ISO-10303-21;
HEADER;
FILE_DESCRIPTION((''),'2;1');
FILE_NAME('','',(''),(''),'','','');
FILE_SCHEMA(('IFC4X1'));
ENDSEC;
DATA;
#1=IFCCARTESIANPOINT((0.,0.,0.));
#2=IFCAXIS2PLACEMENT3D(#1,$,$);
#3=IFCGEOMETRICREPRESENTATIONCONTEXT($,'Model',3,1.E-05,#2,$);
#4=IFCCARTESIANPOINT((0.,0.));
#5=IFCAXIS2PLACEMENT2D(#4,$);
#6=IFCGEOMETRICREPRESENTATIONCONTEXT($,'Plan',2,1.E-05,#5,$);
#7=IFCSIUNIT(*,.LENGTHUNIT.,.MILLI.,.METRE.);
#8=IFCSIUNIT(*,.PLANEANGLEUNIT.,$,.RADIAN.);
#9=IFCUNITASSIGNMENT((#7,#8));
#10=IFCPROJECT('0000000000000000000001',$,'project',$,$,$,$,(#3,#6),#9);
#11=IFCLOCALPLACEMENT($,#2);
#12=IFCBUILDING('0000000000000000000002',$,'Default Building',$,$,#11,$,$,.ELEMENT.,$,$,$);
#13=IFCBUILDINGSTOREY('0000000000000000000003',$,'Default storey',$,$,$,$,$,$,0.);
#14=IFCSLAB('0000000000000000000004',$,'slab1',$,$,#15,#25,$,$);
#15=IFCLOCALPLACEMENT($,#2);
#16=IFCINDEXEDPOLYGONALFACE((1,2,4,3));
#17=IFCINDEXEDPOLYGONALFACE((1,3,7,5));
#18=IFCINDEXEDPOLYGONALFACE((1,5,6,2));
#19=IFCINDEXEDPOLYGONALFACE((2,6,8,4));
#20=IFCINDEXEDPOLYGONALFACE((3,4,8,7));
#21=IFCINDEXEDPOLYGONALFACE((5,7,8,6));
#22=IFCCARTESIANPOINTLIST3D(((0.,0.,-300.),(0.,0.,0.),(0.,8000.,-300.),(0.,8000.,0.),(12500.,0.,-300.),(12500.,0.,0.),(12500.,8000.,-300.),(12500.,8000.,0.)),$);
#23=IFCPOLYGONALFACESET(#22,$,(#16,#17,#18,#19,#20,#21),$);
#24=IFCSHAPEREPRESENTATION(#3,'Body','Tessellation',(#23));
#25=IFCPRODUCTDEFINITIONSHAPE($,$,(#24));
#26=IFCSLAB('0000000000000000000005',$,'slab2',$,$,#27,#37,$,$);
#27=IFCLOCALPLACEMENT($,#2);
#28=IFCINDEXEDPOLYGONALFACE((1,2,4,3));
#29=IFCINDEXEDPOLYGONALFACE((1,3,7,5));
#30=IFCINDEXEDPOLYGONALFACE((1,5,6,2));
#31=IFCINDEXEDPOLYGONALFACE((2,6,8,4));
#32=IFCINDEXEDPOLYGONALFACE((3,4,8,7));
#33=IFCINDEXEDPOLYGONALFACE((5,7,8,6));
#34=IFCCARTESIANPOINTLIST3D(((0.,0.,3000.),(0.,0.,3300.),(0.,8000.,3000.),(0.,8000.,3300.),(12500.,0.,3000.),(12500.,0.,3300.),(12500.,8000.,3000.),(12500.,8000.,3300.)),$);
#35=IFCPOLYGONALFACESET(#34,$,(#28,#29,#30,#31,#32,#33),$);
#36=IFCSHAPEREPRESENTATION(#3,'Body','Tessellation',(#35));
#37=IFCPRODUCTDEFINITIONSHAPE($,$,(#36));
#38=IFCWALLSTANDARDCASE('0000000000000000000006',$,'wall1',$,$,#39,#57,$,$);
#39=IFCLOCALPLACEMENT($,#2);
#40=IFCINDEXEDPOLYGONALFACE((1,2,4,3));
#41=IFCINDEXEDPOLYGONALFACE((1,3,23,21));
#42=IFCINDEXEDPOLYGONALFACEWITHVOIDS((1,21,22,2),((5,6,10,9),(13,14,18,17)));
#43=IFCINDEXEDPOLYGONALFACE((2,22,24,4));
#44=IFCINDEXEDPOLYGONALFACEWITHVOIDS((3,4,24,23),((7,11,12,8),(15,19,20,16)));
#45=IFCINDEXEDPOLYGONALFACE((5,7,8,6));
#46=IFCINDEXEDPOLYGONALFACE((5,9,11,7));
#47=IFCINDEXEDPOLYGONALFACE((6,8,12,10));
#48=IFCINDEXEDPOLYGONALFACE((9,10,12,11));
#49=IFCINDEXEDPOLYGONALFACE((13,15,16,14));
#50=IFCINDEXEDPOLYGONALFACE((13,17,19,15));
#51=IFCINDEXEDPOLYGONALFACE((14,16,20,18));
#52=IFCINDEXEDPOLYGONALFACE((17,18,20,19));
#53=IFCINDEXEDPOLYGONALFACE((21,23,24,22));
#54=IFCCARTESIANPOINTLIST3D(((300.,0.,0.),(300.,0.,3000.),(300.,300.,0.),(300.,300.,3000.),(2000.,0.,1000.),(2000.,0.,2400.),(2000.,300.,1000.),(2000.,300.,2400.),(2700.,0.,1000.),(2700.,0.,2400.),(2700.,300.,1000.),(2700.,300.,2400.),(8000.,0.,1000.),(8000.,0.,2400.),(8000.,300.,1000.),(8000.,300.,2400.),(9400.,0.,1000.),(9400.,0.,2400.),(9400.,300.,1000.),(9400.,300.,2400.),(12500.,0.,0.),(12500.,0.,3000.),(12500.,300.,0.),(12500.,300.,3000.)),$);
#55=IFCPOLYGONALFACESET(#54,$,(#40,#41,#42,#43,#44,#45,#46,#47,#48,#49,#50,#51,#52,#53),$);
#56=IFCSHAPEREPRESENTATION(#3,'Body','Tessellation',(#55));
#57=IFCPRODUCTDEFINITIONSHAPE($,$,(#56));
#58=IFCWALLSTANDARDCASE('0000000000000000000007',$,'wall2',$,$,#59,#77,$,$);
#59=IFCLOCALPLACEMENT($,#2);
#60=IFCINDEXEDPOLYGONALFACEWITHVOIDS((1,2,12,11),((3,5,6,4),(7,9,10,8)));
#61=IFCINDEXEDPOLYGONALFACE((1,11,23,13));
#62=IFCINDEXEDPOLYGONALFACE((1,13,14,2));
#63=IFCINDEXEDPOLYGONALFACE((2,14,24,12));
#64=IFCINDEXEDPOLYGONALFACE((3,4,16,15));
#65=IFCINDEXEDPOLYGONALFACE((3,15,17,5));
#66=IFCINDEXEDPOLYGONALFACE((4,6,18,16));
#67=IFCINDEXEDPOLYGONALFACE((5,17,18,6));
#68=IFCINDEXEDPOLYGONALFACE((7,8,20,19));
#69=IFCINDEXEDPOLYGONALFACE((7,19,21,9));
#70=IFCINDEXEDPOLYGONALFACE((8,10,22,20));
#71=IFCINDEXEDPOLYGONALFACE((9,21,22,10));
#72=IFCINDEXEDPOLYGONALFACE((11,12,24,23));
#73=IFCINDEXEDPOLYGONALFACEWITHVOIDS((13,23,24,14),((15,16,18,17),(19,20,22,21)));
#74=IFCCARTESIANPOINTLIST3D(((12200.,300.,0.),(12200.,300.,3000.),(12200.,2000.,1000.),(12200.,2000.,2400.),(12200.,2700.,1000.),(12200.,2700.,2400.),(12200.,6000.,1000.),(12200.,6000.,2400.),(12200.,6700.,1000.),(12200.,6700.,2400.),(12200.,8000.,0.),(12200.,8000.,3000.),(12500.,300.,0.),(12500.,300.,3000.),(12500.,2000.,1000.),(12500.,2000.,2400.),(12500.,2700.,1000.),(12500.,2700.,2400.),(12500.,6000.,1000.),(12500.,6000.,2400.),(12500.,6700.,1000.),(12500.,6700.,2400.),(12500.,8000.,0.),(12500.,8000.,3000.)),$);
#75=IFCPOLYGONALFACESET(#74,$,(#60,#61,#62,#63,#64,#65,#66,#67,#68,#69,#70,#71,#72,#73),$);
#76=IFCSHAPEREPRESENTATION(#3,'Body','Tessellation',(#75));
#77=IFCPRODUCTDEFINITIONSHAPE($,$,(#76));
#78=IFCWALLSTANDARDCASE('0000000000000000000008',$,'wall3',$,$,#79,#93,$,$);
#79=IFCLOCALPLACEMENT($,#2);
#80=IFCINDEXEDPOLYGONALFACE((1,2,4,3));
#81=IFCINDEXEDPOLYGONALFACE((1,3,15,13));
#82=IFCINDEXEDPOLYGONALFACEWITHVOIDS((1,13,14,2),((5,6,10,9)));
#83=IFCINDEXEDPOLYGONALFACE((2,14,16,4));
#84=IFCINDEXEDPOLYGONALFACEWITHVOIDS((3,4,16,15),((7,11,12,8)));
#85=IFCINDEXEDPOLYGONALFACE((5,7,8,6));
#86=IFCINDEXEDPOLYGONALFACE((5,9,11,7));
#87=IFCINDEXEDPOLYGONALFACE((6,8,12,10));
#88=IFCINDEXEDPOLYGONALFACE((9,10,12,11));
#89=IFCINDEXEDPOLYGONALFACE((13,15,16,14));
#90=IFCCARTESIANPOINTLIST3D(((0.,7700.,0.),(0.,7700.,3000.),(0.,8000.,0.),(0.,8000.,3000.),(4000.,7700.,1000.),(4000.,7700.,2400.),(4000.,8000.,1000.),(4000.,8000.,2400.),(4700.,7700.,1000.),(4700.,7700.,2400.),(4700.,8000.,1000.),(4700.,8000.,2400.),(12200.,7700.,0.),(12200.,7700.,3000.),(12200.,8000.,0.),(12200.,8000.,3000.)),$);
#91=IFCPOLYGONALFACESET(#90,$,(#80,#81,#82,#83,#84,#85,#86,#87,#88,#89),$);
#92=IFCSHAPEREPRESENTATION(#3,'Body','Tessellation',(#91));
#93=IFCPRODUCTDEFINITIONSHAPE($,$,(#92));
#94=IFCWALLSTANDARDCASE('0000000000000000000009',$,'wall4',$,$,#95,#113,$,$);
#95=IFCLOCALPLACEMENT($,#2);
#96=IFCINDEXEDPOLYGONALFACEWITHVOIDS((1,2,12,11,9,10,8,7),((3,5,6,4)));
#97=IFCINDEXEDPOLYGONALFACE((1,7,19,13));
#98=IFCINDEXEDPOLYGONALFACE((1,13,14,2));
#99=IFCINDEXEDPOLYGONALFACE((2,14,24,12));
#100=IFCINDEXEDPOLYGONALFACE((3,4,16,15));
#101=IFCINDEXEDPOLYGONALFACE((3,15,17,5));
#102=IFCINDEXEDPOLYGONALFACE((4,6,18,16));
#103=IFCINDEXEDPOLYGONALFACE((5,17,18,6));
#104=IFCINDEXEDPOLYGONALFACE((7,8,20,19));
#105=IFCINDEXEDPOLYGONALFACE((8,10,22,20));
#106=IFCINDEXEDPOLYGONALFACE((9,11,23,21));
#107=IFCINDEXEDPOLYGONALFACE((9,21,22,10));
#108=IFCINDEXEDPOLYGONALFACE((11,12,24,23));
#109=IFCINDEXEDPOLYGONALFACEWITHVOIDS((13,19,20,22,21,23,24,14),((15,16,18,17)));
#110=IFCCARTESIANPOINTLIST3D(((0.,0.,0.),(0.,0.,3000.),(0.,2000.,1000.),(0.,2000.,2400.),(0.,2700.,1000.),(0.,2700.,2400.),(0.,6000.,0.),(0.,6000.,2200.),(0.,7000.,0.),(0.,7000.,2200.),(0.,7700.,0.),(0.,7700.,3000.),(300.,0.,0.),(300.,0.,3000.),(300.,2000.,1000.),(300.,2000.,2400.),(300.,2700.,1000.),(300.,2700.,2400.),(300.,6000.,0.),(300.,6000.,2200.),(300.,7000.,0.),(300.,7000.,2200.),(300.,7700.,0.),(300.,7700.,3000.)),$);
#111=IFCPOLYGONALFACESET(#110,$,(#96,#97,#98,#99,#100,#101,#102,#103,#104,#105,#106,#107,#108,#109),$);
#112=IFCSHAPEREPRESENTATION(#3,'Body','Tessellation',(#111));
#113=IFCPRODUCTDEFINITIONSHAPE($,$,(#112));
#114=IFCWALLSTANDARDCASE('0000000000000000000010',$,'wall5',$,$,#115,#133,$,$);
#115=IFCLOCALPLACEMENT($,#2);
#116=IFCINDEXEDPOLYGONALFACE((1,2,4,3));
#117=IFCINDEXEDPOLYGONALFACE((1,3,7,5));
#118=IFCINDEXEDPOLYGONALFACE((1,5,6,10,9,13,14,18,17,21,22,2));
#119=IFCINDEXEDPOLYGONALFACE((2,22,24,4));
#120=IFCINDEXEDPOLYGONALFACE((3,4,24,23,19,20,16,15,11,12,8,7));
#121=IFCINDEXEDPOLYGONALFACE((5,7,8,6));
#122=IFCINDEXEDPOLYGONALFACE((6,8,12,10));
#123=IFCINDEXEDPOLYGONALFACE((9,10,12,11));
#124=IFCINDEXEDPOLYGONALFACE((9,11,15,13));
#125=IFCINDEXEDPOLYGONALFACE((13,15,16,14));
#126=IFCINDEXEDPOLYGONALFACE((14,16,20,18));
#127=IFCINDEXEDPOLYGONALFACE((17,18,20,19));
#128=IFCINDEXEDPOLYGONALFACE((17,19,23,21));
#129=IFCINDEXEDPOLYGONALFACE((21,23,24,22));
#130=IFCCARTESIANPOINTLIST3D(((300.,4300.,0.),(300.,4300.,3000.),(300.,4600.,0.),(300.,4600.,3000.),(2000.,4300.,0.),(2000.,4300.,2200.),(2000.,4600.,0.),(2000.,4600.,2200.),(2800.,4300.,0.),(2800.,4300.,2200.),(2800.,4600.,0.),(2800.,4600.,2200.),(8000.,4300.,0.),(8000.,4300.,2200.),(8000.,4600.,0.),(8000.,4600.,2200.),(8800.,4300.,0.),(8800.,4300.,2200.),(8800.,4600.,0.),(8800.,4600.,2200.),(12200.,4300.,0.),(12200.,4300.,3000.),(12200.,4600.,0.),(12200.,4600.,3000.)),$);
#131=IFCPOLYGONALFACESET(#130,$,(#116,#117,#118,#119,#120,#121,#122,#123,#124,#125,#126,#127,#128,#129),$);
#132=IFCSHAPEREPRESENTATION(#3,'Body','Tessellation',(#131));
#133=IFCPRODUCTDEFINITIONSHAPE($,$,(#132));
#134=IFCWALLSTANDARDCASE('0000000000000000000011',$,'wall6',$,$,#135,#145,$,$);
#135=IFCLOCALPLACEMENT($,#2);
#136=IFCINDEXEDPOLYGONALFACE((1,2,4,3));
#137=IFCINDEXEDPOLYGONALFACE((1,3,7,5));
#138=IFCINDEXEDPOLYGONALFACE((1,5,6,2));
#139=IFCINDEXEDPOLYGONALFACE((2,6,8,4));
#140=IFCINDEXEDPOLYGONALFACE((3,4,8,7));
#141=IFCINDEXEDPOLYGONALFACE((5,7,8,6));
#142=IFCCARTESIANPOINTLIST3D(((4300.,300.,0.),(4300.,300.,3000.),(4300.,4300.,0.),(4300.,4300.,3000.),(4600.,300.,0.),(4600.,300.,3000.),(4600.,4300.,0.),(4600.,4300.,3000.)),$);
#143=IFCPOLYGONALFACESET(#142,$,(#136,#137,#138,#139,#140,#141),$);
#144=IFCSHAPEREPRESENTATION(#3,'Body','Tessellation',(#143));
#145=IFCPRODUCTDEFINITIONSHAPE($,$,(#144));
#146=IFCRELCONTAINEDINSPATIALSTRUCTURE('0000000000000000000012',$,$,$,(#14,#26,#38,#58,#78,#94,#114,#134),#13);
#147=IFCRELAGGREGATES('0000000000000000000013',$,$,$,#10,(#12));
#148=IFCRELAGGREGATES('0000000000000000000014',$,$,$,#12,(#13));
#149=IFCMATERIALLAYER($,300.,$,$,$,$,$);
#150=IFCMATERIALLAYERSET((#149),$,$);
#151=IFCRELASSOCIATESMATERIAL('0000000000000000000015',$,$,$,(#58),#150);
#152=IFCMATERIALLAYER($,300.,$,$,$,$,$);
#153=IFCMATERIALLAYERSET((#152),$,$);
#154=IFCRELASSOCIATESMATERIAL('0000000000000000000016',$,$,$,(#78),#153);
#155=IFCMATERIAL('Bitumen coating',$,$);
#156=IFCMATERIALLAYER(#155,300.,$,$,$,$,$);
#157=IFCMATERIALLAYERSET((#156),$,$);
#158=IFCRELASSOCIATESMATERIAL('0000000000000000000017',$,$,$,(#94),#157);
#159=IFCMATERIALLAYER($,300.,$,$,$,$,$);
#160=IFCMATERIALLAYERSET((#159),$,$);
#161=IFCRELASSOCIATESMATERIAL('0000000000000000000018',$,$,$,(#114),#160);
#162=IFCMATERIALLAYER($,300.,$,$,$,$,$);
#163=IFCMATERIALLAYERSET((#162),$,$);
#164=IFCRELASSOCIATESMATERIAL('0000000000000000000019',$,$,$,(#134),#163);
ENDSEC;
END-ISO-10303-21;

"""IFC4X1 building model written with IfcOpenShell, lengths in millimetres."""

from ifc_helpers import new_model, si_unit, frame, origin, origin_2d, place, context, project, spatial, polyline, outline, extrude, material, layer, layer_set, layer_usage, element, save


model = new_model("IFC4X1")

# Units and contexts
model_context = context("Model", 3, precision=1e-05, world=origin())
plan_context = context("Plan", 2, precision=1e-05, world=origin_2d())
ifc_project = project(units=[si_unit("LENGTHUNIT", "METRE", prefix="MILLI"), si_unit("PLANEANGLEUNIT", "RADIAN")], contexts=[model_context, plan_context])

# Building, storey
building_placement = place(None, origin())
building = spatial("IfcBuilding", under=ifc_project, at=building_placement, Name="Default Building", CompositionType="ELEMENT")
storey = spatial("IfcBuildingStorey", under=building, Name="Default storey", Elevation=0.0)

# Slabs
slab_1_placement = place(None, frame((0.0, 0.0, -300.0), z_axis=(0.0, 0.0, 1.0)))
element("IfcSlab", 1, at=slab_1_placement, inside=storey, Name="slab1", context=model_context, shape_type="SweptSolid", body=[
    extrude(outline(polyline([(0.0, 0.0), (12500.0, 0.0), (12500.0, 8000.0), (0.0, 8000.0), (0.0, 0.0)])), origin(), (0.0, 0.0, 1.0), 300.0),
])
slab_2_placement = place(None, frame((0.0, 0.0, 3000.0), z_axis=(0.0, 0.0, 1.0)))
element("IfcSlab", 2, at=slab_2_placement, inside=storey, Name="slab2", context=model_context, shape_type="SweptSolid", body=[
    extrude(outline(polyline([(0.0, 0.0), (0.0, 8000.0), (12500.0, 8000.0), (12500.0, 0.0), (0.0, 0.0)])), origin(), (0.0, 0.0, 1.0), 300.0),
])

# Walls, openings
wall_1_placement = place(None, frame((0.0, 0.0, 0.0), z_axis=(0.0, 0.0, 1.0)))
wall_1 = element("IfcWallStandardCase", 3, at=wall_1_placement, inside=storey, Name="wall1", context=model_context, shape_type="SweptSolid", body=[
    extrude(outline(polyline([(300.0, 0.0), (12500.0, 0.0), (12500.0, 300.0), (300.0, 300.0), (300.0, 0.0)])), origin(), (0.0, 0.0, 1.0), 3000.0),
])
opening_1_placement = place(None, frame((0.0, 0.0, 1000.0), z_axis=(0.0, 0.0, 1.0)))
element("IfcOpeningElement", 4, at=opening_1_placement, inside=storey, cuts=wall_1, context=model_context, shape_type="SweptSolid", body=[
    extrude(outline(polyline([(8000.0, 0.0), (9400.0, 0.0), (9400.0, 300.0), (8000.0, 300.0), (8000.0, 0.0)])), origin(), (0.0, 0.0, 1.0), 1400.0),
])
opening_2_placement = place(None, frame((0.0, 0.0, 1000.0), z_axis=(0.0, 0.0, 1.0)))
element("IfcOpeningElement", 5, at=opening_2_placement, inside=storey, cuts=wall_1, context=model_context, shape_type="SweptSolid", body=[
    extrude(outline(polyline([(2000.0, 0.0), (2700.0, 0.0), (2700.0, 300.0), (2000.0, 300.0), (2000.0, 0.0)])), origin(), (0.0, 0.0, 1.0), 1400.0),
])
ifc_layer_1 = layer(None, 300.0)
ifc_layer_set_1 = layer_set([ifc_layer_1])
ifc_layer_usage_1 = layer_usage(ifc_layer_set_1, "AXIS2", "NEGATIVE", 150.0)
wall_2_placement = place(None, frame((0.0, 0.0, 0.0), z_axis=(0.0, 0.0, 1.0)))
wall_2 = element("IfcWallStandardCase", 6, at=wall_2_placement, inside=storey, material=ifc_layer_usage_1, Name="wall2", context=model_context, shape_type="SweptSolid", body=[
    extrude(outline(polyline([(12500.0, 300.0), (12500.0, 8000.0), (12200.0, 8000.0), (12200.0, 300.0), (12500.0, 300.0)])), origin(), (0.0, 0.0, 1.0), 3000.0),
])
opening_3_placement = place(None, frame((0.0, 0.0, 1000.0), z_axis=(0.0, 0.0, 1.0)))
element("IfcOpeningElement", 7, at=opening_3_placement, inside=storey, cuts=wall_2, context=model_context, shape_type="SweptSolid", body=[
    extrude(outline(polyline([(12500.0, 6000.0), (12500.0, 6700.0), (12200.0, 6700.0), (12200.0, 6000.0), (12500.0, 6000.0)])), origin(), (0.0, 0.0, 1.0), 1400.0),
])
opening_4_placement = place(None, frame((0.0, 0.0, 1000.0), z_axis=(0.0, 0.0, 1.0)))
element("IfcOpeningElement", 8, at=opening_4_placement, inside=storey, cuts=wall_2, context=model_context, shape_type="SweptSolid", body=[
    extrude(outline(polyline([(12500.0, 2000.0), (12500.0, 2700.0), (12200.0, 2700.0), (12200.0, 2000.0), (12500.0, 2000.0)])), origin(), (0.0, 0.0, 1.0), 1400.0),
])

# Wall, opening
ifc_layer_2 = layer(None, 300.0)
ifc_layer_set_2 = layer_set([ifc_layer_2])
ifc_layer_usage_2 = layer_usage(ifc_layer_set_2, "AXIS2", "NEGATIVE", 150.0)
wall_3_placement = place(None, frame((0.0, 0.0, 0.0), z_axis=(0.0, 0.0, 1.0)))
wall_3 = element("IfcWallStandardCase", 9, at=wall_3_placement, inside=storey, material=ifc_layer_usage_2, Name="wall3", context=model_context, shape_type="SweptSolid", body=[
    extrude(outline(polyline([(12200.0, 8000.0), (0.0, 8000.0), (0.0, 7700.0), (12200.0, 7700.0), (12200.0, 8000.0)])), origin(), (0.0, 0.0, 1.0), 3000.0),
])
opening_5_placement = place(None, frame((0.0, 0.0, 1000.0), z_axis=(0.0, 0.0, 1.0)))
element("IfcOpeningElement", 10, at=opening_5_placement, inside=storey, cuts=wall_3, context=model_context, shape_type="SweptSolid", body=[
    extrude(outline(polyline([(4000.0, 8000.0), (4700.0, 8000.0), (4700.0, 7700.0), (4000.0, 7700.0), (4000.0, 8000.0)])), origin(), (0.0, 0.0, 1.0), 1400.0),
])

# Walls, openings
ifc_material = material(Name="Bitumen coating")
ifc_layer_3 = layer(ifc_material, 300.0)
ifc_layer_set_3 = layer_set([ifc_layer_3])
ifc_layer_usage_3 = layer_usage(ifc_layer_set_3, "AXIS2", "NEGATIVE", 150.0)
wall_4_placement = place(None, frame((0.0, 0.0, 0.0), z_axis=(0.0, 0.0, 1.0)))
wall_4 = element("IfcWallStandardCase", 11, at=wall_4_placement, inside=storey, material=ifc_layer_usage_3, Name="wall4", context=model_context, shape_type="SweptSolid", body=[
    extrude(outline(polyline([(0.0, 7700.0), (0.0, 0.0), (300.0, 0.0), (300.0, 7700.0), (0.0, 7700.0)])), origin(), (0.0, 0.0, 1.0), 3000.0),
])
opening_6_placement = place(None, frame((0.0, 0.0, 0.0), z_axis=(0.0, 0.0, 1.0)))
element("IfcOpeningElement", 12, at=opening_6_placement, inside=storey, cuts=wall_4, context=model_context, shape_type="SweptSolid", body=[
    extrude(outline(polyline([(0.0, 6000.0), (0.0, 7000.0), (300.0, 7000.0), (300.0, 6000.0), (0.0, 6000.0)])), origin(), (0.0, 0.0, 1.0), 2200.0),
])
opening_7_placement = place(None, frame((0.0, 0.0, 1000.0), z_axis=(0.0, 0.0, 1.0)))
element("IfcOpeningElement", 13, at=opening_7_placement, inside=storey, cuts=wall_4, context=model_context, shape_type="SweptSolid", body=[
    extrude(outline(polyline([(0.0, 2000.0), (0.0, 2700.0), (300.0, 2700.0), (300.0, 2000.0), (0.0, 2000.0)])), origin(), (0.0, 0.0, 1.0), 1400.0),
])
ifc_layer_4 = layer(None, 300.0)
ifc_layer_set_4 = layer_set([ifc_layer_4])
ifc_layer_usage_4 = layer_usage(ifc_layer_set_4, "AXIS2", "NEGATIVE", 150.0)
wall_5_placement = place(None, frame((0.0, 0.0, 0.0), z_axis=(0.0, 0.0, 1.0)))
wall_5 = element("IfcWallStandardCase", 14, at=wall_5_placement, inside=storey, material=ifc_layer_usage_4, Name="wall5", context=model_context, shape_type="SweptSolid", body=[
    extrude(outline(polyline([(12200.0, 4600.0), (300.0, 4600.0), (300.0, 4300.0), (12200.0, 4300.0), (12200.0, 4600.0)])), origin(), (0.0, 0.0, 1.0), 3000.0),
])
opening_8_placement = place(None, frame((0.0, 0.0, 0.0), z_axis=(0.0, 0.0, 1.0)))
element("IfcOpeningElement", 15, at=opening_8_placement, inside=storey, cuts=wall_5, context=model_context, shape_type="SweptSolid", body=[
    extrude(outline(polyline([(2000.0, 4600.0), (2800.0, 4600.0), (2800.0, 4300.0), (2000.0, 4300.0), (2000.0, 4600.0)])), origin(), (0.0, 0.0, 1.0), 2200.0),
])
opening_9_placement = place(None, frame((0.0, 0.0, 0.0), z_axis=(0.0, 0.0, 1.0)))
element("IfcOpeningElement", 16, at=opening_9_placement, inside=storey, cuts=wall_5, context=model_context, shape_type="SweptSolid", body=[
    extrude(outline(polyline([(8000.0, 4600.0), (8800.0, 4600.0), (8800.0, 4300.0), (8000.0, 4300.0), (8000.0, 4600.0)])), origin(), (0.0, 0.0, 1.0), 2200.0),
])

# Wall
ifc_layer_5 = layer(None, 300.0)
ifc_layer_set_5 = layer_set([ifc_layer_5])
ifc_layer_usage_5 = layer_usage(ifc_layer_set_5, "AXIS2", "NEGATIVE", 150.0)
wall_6_placement = place(None, frame((0.0, 0.0, 0.0), z_axis=(0.0, 0.0, 1.0)))
element("IfcWallStandardCase", 17, at=wall_6_placement, inside=storey, material=ifc_layer_usage_5, Name="wall6", context=model_context, shape_type="SweptSolid", body=[
    extrude(outline(polyline([(4300.0, 4300.0), (4300.0, 300.0), (4600.0, 300.0), (4600.0, 4300.0), (4300.0, 4300.0)])), origin(), (0.0, 0.0, 1.0), 3000.0),
])

save(model, "model.ifc")
